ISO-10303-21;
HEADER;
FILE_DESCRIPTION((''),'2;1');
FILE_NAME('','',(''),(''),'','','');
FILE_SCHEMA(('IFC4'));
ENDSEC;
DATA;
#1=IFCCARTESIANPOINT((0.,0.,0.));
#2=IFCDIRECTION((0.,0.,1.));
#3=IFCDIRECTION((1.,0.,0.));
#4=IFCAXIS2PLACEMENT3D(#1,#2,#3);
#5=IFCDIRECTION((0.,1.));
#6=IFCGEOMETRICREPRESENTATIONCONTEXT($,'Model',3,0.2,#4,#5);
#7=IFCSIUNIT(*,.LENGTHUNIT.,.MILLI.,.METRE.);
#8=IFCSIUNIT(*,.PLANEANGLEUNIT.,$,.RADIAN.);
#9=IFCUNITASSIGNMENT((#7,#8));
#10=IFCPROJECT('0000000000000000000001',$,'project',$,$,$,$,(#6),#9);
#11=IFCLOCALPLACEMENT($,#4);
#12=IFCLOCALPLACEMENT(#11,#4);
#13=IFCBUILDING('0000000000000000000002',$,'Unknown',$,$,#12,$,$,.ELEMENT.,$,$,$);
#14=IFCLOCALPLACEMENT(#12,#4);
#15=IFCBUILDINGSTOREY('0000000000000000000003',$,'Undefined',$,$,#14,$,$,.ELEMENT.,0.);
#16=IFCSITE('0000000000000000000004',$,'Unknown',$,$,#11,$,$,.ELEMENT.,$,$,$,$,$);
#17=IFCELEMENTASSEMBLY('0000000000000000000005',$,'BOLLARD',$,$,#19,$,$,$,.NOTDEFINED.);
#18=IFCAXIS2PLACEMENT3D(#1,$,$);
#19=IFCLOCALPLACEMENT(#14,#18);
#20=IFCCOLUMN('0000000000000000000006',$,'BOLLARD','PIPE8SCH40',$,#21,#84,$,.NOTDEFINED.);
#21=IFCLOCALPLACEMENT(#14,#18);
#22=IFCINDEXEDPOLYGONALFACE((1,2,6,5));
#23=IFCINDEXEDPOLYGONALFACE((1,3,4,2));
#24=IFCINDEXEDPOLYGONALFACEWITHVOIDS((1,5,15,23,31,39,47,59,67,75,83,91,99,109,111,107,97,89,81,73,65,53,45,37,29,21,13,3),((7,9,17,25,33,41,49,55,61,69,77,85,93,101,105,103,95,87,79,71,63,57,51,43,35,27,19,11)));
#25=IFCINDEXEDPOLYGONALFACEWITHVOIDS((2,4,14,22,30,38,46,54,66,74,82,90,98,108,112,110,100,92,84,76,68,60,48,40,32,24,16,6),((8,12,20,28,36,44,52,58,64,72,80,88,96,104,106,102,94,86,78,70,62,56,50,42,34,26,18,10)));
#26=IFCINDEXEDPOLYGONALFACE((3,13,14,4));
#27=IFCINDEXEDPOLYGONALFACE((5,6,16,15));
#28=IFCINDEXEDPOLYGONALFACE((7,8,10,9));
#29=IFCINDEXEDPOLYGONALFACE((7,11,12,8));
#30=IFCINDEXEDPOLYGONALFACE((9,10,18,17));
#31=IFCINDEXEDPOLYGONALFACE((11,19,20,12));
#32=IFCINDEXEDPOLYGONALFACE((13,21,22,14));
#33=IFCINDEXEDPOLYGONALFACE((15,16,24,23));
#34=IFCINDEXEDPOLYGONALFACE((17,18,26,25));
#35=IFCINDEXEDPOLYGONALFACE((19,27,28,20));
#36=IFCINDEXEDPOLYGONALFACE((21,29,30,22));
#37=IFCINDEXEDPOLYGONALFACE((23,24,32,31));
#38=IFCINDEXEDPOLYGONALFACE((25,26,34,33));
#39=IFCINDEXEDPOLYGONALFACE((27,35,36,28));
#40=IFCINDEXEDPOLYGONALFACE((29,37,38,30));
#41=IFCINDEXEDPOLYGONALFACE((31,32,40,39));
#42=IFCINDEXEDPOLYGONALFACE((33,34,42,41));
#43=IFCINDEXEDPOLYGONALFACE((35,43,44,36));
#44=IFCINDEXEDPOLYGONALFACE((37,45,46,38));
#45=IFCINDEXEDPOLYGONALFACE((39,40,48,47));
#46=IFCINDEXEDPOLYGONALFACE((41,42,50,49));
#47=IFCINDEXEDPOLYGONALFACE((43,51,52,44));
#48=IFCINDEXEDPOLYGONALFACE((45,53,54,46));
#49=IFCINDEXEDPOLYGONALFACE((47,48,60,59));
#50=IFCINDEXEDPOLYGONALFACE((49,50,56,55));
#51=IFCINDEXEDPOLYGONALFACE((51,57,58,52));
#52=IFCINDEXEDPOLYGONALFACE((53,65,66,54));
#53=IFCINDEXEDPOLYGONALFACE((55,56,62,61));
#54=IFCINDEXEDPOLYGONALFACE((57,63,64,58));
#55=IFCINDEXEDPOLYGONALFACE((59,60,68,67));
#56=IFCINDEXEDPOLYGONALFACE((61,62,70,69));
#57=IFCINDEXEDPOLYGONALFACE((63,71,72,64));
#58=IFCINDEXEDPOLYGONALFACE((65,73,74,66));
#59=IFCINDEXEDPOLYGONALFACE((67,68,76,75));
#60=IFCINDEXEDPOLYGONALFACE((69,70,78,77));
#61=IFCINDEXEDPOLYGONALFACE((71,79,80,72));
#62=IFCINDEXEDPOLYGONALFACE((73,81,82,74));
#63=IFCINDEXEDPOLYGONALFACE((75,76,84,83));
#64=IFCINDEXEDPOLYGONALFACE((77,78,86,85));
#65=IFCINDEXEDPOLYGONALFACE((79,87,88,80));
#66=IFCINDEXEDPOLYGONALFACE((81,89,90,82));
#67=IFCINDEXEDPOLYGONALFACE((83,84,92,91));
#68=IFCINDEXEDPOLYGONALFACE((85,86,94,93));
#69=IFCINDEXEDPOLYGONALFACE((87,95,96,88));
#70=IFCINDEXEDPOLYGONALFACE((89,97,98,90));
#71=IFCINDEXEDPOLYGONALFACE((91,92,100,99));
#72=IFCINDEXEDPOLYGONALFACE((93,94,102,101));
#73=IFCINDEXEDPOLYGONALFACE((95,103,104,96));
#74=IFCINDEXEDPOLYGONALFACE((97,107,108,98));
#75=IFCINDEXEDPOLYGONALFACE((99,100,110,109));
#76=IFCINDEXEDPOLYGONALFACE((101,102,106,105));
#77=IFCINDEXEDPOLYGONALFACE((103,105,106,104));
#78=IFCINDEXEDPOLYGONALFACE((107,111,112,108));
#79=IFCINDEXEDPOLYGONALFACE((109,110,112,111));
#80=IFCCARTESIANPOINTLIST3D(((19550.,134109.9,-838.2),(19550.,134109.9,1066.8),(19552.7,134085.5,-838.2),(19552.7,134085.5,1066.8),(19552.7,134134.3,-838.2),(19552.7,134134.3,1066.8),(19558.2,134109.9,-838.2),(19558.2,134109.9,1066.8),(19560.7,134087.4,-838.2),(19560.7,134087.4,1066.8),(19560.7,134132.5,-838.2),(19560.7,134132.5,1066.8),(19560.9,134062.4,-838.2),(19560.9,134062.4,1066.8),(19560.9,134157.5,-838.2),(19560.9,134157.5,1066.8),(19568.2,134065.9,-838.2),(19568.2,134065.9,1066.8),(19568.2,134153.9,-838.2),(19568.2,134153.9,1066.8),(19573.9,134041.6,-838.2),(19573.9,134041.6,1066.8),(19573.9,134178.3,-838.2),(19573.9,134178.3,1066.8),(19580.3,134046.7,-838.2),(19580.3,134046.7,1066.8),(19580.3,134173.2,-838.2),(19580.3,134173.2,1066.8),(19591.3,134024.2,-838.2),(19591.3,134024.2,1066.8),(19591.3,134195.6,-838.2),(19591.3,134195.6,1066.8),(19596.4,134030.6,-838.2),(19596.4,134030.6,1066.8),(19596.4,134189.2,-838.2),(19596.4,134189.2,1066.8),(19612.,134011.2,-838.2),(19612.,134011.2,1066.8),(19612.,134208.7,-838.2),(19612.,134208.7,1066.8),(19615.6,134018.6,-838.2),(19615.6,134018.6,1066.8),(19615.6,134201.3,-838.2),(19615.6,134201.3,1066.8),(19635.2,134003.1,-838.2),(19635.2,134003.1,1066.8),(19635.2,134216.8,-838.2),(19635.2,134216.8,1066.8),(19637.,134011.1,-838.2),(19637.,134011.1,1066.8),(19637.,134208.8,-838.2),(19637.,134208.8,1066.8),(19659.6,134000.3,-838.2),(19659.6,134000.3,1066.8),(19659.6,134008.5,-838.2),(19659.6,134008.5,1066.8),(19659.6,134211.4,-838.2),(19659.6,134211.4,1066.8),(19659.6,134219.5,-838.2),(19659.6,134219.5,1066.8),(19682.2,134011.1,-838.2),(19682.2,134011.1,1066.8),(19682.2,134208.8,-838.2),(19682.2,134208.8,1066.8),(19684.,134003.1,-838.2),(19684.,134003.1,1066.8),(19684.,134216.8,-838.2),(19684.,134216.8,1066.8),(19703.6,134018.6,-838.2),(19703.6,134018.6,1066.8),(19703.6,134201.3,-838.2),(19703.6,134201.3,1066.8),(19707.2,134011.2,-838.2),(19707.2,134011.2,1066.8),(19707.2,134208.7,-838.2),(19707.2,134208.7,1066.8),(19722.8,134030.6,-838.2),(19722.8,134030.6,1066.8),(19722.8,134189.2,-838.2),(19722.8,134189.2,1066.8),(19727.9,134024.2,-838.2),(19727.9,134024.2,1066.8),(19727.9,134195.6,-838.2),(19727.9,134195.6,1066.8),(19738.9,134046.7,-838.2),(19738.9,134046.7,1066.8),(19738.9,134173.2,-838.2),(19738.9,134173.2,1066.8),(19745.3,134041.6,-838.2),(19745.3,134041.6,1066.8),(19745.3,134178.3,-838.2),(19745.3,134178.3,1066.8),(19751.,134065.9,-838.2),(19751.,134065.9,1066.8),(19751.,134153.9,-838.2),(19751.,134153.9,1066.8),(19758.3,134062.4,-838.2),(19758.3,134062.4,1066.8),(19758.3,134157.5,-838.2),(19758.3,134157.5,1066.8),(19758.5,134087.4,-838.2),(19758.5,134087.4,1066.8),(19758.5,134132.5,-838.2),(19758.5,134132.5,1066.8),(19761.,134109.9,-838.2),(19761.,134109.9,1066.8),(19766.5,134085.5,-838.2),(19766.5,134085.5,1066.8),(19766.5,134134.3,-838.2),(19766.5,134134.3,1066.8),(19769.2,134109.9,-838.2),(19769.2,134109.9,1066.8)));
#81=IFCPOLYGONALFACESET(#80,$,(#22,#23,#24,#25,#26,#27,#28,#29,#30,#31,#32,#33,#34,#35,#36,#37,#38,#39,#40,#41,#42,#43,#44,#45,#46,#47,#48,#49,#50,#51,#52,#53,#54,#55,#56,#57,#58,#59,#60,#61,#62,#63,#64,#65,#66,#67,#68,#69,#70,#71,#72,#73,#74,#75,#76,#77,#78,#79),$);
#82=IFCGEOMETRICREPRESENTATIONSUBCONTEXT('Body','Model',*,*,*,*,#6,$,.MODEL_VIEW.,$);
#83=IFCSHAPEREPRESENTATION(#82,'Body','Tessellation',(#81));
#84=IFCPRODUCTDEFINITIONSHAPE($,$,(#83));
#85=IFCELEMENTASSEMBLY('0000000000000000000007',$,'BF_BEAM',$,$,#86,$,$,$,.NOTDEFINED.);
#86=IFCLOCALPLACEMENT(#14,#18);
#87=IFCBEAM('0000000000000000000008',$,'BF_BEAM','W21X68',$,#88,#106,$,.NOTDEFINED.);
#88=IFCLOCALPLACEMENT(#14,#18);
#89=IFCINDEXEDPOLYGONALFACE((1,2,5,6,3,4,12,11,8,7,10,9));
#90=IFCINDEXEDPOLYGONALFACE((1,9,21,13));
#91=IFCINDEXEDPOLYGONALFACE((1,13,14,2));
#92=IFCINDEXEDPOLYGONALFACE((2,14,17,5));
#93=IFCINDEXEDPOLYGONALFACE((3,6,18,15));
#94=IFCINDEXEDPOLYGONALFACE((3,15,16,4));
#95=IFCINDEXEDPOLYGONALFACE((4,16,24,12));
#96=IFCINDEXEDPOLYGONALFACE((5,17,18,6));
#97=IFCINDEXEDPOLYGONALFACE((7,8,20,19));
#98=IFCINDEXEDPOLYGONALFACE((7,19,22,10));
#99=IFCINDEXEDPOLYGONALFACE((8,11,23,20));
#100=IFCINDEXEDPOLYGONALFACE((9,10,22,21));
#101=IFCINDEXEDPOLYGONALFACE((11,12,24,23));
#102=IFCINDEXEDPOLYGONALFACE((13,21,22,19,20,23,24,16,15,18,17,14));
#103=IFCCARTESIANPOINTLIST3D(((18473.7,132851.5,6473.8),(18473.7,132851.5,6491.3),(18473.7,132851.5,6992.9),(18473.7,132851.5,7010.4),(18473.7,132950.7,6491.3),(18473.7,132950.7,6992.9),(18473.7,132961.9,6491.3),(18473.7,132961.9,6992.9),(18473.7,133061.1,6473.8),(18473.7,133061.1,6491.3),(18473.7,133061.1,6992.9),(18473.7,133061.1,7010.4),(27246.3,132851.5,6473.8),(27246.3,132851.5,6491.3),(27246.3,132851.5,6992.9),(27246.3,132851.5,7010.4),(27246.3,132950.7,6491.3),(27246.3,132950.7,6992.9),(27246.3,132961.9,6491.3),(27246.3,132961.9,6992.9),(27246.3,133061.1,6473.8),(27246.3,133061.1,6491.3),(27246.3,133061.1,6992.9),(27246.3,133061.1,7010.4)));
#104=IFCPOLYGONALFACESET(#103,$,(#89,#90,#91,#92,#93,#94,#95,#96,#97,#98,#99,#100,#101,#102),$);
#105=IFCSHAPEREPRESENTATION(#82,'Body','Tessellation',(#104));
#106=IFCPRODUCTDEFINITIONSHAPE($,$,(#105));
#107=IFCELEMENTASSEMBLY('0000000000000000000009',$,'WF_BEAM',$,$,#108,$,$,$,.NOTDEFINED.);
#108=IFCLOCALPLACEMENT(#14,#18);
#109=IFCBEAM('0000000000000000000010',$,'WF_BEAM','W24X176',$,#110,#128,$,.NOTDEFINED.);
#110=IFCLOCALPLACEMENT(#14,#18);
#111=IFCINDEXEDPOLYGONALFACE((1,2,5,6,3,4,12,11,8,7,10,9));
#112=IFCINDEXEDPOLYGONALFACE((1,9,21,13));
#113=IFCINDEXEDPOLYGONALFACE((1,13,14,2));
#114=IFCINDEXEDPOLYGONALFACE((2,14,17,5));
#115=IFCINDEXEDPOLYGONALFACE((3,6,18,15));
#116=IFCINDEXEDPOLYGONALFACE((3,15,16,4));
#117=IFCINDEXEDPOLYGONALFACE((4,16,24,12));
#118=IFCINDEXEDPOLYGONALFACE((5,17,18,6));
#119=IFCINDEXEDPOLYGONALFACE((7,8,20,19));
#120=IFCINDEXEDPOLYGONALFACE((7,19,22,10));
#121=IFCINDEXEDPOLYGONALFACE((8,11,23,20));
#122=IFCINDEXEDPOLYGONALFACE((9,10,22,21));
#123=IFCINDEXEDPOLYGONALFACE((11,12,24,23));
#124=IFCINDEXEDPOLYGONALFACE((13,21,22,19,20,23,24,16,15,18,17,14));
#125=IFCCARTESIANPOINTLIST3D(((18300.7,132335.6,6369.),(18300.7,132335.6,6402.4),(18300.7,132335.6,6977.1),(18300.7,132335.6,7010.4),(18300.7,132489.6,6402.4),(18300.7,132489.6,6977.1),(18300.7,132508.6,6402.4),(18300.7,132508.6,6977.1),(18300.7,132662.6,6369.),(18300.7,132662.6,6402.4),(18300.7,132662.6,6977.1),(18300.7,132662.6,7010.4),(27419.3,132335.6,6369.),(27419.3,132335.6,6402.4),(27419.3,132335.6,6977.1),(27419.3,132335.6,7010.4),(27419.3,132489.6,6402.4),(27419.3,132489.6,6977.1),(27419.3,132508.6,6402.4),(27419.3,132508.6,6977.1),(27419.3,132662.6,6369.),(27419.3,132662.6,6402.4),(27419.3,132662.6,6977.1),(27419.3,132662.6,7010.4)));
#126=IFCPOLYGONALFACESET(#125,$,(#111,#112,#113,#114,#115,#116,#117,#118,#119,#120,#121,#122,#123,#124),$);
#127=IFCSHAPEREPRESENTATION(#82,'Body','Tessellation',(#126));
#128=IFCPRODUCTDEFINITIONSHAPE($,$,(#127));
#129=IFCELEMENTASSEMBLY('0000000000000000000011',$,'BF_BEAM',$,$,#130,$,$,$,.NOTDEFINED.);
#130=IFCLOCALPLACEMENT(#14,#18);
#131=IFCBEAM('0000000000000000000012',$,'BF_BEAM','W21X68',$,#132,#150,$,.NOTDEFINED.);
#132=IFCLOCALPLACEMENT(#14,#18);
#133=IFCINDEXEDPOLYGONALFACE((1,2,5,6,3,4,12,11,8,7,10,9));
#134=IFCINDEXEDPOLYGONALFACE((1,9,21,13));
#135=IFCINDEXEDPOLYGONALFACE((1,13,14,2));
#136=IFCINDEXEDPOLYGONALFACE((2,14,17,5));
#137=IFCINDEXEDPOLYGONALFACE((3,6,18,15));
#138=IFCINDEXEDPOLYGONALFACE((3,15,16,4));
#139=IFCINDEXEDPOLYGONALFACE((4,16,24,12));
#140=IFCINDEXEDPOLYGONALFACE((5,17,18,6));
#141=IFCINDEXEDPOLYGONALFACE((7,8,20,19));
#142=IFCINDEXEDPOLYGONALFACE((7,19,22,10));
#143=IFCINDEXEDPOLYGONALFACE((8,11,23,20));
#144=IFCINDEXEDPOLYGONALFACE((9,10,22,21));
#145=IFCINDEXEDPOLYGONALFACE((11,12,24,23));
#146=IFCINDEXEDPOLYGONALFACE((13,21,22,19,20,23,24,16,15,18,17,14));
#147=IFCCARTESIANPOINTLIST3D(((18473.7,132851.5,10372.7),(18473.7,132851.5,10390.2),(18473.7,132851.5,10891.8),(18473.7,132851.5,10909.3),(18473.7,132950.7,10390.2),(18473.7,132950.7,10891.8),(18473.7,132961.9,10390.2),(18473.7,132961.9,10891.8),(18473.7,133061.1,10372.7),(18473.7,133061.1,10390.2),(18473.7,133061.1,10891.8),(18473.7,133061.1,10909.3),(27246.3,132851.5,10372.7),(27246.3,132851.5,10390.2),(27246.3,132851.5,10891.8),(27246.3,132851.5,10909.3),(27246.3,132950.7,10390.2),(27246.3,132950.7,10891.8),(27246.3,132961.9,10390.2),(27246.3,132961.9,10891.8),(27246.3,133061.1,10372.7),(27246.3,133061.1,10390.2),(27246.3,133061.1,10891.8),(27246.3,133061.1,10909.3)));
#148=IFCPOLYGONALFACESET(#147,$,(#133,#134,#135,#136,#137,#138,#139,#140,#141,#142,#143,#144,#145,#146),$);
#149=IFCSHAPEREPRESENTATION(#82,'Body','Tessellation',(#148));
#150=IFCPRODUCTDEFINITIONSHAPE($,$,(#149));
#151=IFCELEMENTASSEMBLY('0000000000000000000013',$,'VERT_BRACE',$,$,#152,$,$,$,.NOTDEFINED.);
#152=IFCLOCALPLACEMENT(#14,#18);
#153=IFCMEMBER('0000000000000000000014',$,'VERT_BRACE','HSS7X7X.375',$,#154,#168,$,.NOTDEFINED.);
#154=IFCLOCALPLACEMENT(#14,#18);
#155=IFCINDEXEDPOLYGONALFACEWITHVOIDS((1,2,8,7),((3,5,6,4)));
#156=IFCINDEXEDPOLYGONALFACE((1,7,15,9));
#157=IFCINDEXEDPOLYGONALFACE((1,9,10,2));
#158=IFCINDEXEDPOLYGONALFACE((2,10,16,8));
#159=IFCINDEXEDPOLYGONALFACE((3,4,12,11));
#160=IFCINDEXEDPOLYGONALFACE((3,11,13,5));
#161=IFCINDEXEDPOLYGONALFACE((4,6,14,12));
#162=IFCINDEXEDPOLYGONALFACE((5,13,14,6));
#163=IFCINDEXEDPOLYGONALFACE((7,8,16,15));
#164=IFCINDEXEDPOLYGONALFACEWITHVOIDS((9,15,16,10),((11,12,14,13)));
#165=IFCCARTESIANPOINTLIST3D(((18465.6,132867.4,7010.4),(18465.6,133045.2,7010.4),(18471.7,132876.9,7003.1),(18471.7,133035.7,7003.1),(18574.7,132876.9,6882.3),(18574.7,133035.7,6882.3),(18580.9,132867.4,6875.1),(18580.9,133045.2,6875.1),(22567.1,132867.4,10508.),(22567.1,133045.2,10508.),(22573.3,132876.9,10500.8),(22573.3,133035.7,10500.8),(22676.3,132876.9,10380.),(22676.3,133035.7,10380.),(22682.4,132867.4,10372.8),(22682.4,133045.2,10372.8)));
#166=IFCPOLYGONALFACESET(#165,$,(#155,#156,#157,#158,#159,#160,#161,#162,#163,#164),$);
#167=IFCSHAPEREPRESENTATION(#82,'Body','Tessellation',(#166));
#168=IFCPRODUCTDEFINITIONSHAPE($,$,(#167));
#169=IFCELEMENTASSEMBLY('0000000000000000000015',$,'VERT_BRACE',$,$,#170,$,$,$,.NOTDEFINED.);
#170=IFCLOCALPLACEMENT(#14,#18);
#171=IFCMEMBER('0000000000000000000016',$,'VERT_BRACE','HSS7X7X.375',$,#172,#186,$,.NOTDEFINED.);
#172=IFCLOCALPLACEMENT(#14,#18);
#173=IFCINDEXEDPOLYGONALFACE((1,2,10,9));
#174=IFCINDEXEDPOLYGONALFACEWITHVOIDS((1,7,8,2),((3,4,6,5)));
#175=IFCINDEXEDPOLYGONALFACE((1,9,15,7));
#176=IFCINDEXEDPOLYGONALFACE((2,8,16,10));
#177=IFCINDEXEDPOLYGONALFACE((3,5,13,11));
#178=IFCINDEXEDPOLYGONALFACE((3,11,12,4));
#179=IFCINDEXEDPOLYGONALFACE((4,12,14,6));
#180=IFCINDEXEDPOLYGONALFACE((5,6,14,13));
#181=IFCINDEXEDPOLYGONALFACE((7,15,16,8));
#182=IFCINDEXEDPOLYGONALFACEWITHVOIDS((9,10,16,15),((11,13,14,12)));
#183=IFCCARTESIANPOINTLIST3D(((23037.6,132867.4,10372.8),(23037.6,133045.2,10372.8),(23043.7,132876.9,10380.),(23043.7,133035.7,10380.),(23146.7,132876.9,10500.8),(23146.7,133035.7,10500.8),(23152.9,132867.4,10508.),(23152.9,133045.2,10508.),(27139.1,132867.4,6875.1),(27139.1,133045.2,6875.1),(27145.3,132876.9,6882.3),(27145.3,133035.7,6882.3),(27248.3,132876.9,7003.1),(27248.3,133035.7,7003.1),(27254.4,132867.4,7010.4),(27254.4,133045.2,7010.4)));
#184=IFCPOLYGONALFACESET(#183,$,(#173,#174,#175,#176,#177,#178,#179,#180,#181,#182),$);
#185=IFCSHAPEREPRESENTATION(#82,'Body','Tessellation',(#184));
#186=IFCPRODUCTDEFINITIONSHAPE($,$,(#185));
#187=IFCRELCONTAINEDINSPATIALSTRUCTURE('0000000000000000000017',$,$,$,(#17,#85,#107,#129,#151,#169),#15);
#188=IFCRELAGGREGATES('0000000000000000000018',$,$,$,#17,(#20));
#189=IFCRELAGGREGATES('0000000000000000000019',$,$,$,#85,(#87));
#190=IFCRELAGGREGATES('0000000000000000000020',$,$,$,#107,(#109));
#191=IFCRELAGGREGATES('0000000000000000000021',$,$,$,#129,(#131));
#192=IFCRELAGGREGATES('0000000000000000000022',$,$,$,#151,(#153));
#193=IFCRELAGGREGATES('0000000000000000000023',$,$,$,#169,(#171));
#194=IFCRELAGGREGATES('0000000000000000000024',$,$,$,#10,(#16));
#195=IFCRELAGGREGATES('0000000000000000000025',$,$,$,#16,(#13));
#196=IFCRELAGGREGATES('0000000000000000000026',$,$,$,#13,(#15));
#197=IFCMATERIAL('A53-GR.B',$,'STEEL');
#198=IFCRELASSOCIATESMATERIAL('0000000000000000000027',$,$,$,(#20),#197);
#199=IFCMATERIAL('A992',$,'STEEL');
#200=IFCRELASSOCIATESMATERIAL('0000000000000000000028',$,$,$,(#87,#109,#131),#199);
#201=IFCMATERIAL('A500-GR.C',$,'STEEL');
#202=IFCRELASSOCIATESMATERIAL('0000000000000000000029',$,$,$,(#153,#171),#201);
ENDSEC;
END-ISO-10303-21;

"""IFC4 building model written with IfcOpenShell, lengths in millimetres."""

from ifc_helpers import new_model, si_unit, direction, frame, origin_with_axes, place, context, subcontext, project, spatial, line, indexed_curve, outline, extrude, material, element, aggregate, save


model = new_model("IFC4")

# Units and contexts
model_context = context("Model", 3, precision=0.2, world=origin_with_axes(), true_north=direction((0.0, 1.0)))
body_context = subcontext(model_context, "Body", "Model", "MODEL_VIEW")
ifc_project = project(units=[si_unit("LENGTHUNIT", "METRE", prefix="MILLI"), si_unit("PLANEANGLEUNIT", "RADIAN")], contexts=[model_context])

# Site, building, storey
site_placement = place(None, origin_with_axes())
site = spatial("IfcSite", under=ifc_project, at=site_placement, Name="Unknown", CompositionType="ELEMENT")
building_placement = place(site_placement, origin_with_axes())
building = spatial("IfcBuilding", under=site, at=building_placement, Name="Unknown", CompositionType="ELEMENT")
storey_placement = place(building_placement, origin_with_axes())
storey = spatial("IfcBuildingStorey", under=building, at=storey_placement, Name="Undefined", CompositionType="ELEMENT", Elevation=0.0)

# Element assembly, column
ifc_material_1 = material(Name="A992", Category="STEEL")
ifc_material_2 = material(Name="A500-GR.C", Category="STEEL")
ifc_material_3 = material(Name="A53-GR.B", Category="STEEL")
assembly_1_placement = place(storey_placement, frame((19659.6, 134109.9, -838.2), z_axis=(-1.0, 0.0, 0.0), x_axis=(0.0, 0.0, 1.0)))
assembly_1 = element("IfcElementAssembly", 1, at=assembly_1_placement, inside=storey, Name="BOLLARD", PredefinedType="NOTDEFINED")
column_1_placement = place(assembly_1_placement, origin_with_axes())
column_1 = element("IfcColumn", 2, at=column_1_placement, material=ifc_material_3, Name="BOLLARD", Description="PIPE8SCH40", PredefinedType="NOTDEFINED", context=body_context, shape_type="SolidModel", body=[
    extrude(outline(indexed_curve([(109.6, 0.0), (106.9, 24.4), (98.7, 47.6), (85.7, 68.3), (68.3, 85.7), (47.6, 98.7), (24.4, 106.9), (0.0, 109.6), (-24.4, 106.9), (-47.6, 98.7), (-68.3, 85.7), (-85.7, 68.3), (-98.7, 47.6), (-106.9, 24.4), (-109.6, 0.0), (-106.9, -24.4), (-98.7, -47.6), (-85.7, -68.3), (-68.3, -85.7), (-47.6, -98.7), (-24.4, -106.9), (0.0, -109.6), (24.4, -106.9), (47.6, -98.7), (68.3, -85.7), (85.7, -68.3), (98.7, -47.6), (106.9, -24.4)], segments=[line(1, 2, 3, 4, 5, 6, 7, 8, 9, 10, 11, 12, 13, 14, 15, 16, 17, 18, 19, 20, 21, 22, 23, 24, 25, 26, 27, 28, 1)]), holes=[indexed_curve([(101.4, 0.0), (98.9, -22.6), (91.4, -44.0), (79.3, -63.2), (63.2, -79.3), (44.0, -91.4), (22.6, -98.9), (0.0, -101.4), (-22.6, -98.9), (-44.0, -91.4), (-63.2, -79.3), (-79.3, -63.2), (-91.4, -44.0), (-98.9, -22.6), (-101.4, 0.0), (-98.9, 22.6), (-91.4, 44.0), (-79.3, 63.2), (-63.2, 79.3), (-44.0, 91.4), (-22.6, 98.9), (0.0, 101.4), (22.6, 98.9), (44.0, 91.4), (63.2, 79.3), (79.3, 63.2), (91.4, 44.0), (98.9, 22.6)], segments=[line(1, 2, 3, 4, 5, 6, 7, 8, 9, 10, 11, 12, 13, 14, 15, 16, 17, 18, 19, 20, 21, 22, 23, 24, 25, 26, 27, 28, 1)])]), frame((0.0, 0.0, 0.0), z_axis=(-1.0, 0.0, 0.0), x_axis=(0.0, 0.0, 1.0)), (0.0, 0.0, -1.0), 1905.0),
])
aggregate(assembly_1, [column_1])

# Element assemblies, beams
assembly_2_placement = place(storey_placement, frame((18473.7, 132956.3, 6742.1), z_axis=(0.0, -1.0, 0.0), x_axis=(1.0, 0.0, 0.0)))
assembly_2 = element("IfcElementAssembly", 3, at=assembly_2_placement, inside=storey, Name="BF_BEAM", PredefinedType="NOTDEFINED")
beam_1_placement = place(assembly_2_placement, origin_with_axes())
beam_1 = element("IfcBeam", 4, at=beam_1_placement, material=ifc_material_1, Name="BF_BEAM", Description="W21X68", PredefinedType="NOTDEFINED", context=body_context, shape_type="SolidModel", body=[
    extrude(outline(indexed_curve([(-104.8, -268.3), (104.8, -268.3), (104.8, -250.8), (5.6, -250.8), (5.6, 250.8), (104.8, 250.8), (104.8, 268.3), (-104.8, 268.3), (-104.8, 250.8), (-5.6, 250.8), (-5.6, -250.8), (-104.8, -250.8)], segments=[line(1, 2, 3, 4, 5, 6, 7, 8, 9, 10, 11, 12, 1)])), frame((0.0, 0.0, 0.0), z_axis=(-1.0, 0.0, 0.0), x_axis=(0.0, 0.0, 1.0)), (0.0, 0.0, -1.0), 8772.5),
])
aggregate(assembly_2, [beam_1])
assembly_3_placement = place(storey_placement, frame((18300.7, 132499.1, 6689.7), z_axis=(0.0, -1.0, 0.0), x_axis=(1.0, 0.0, 0.0)))
assembly_3 = element("IfcElementAssembly", 5, at=assembly_3_placement, inside=storey, Name="WF_BEAM", PredefinedType="NOTDEFINED")
beam_2_placement = place(assembly_3_placement, origin_with_axes())
beam_2 = element("IfcBeam", 6, at=beam_2_placement, material=ifc_material_1, Name="WF_BEAM", Description="W24X176", PredefinedType="NOTDEFINED", context=body_context, shape_type="SolidModel", body=[
    extrude(outline(indexed_curve([(-163.5, -320.7), (163.5, -320.7), (163.5, -287.3), (9.5, -287.3), (9.5, 287.3), (163.5, 287.3), (163.5, 320.7), (-163.5, 320.7), (-163.5, 287.3), (-9.5, 287.3), (-9.5, -287.3), (-163.5, -287.3)], segments=[line(1, 2, 3, 4, 5, 6, 7, 8, 9, 10, 11, 12, 1)])), frame((0.0, 0.0, 0.0), z_axis=(-1.0, 0.0, 0.0), x_axis=(0.0, 0.0, 1.0)), (0.0, 0.0, -1.0), 9118.6),
])
aggregate(assembly_3, [beam_2])
assembly_4_placement = place(storey_placement, frame((18473.7, 132956.3, 10641.0), z_axis=(0.0, -1.0, 0.0), x_axis=(1.0, 0.0, 0.0)))
assembly_4 = element("IfcElementAssembly", 7, at=assembly_4_placement, inside=storey, Name="BF_BEAM", PredefinedType="NOTDEFINED")
beam_3_placement = place(assembly_4_placement, origin_with_axes())
beam_3 = element("IfcBeam", 8, at=beam_3_placement, material=ifc_material_1, Name="BF_BEAM", Description="W21X68", PredefinedType="NOTDEFINED", context=body_context, shape_type="SolidModel", body=[
    extrude(outline(indexed_curve([(-104.8, -268.3), (104.8, -268.3), (104.8, -250.8), (5.6, -250.8), (5.6, 250.8), (104.8, 250.8), (104.8, 268.3), (-104.8, 268.3), (-104.8, 250.8), (-5.6, 250.8), (-5.6, -250.8), (-104.8, -250.8)], segments=[line(1, 2, 3, 4, 5, 6, 7, 8, 9, 10, 11, 12, 1)])), frame((0.0, 0.0, 0.0), z_axis=(-1.0, 0.0, 0.0), x_axis=(0.0, 0.0, 1.0)), (0.0, 0.0, -1.0), 8772.5),
])
aggregate(assembly_4, [beam_3])

# Element assemblies, members
assembly_5_placement = place(storey_placement, frame((18523.2, 132956.3, 6942.7), z_axis=(0.0, -1.0, 0.0), x_axis=(0.760895, 0.0, 0.648875)))
assembly_5 = element("IfcElementAssembly", 9, at=assembly_5_placement, inside=storey, Name="VERT_BRACE", PredefinedType="NOTDEFINED")
member_1_placement = place(assembly_5_placement, origin_with_axes())
member_1 = element("IfcMember", 10, at=member_1_placement, material=ifc_material_2, Name="VERT_BRACE", Description="HSS7X7X.375", PredefinedType="NOTDEFINED", context=body_context, shape_type="SolidModel", body=[
    extrude(outline(indexed_curve([(-88.9, -88.9), (88.9, -88.9), (88.9, 88.9), (-88.9, 88.9)], segments=[line(1, 2, 3, 4, 1)]), holes=[indexed_curve([(-79.4, -79.4), (-79.4, 79.4), (79.4, 79.4), (79.4, -79.4)], segments=[line(1, 2, 3, 4, 1)])]), frame((0.0, 0.0, 0.0), z_axis=(-1.0, 0.0, 0.0), x_axis=(0.0, 0.0, 1.0)), (0.0, 0.0, -1.0), 5390.4),
])
aggregate(assembly_5, [member_1])
assembly_6_placement = place(storey_placement, frame((27196.8, 132956.3, 6942.7), z_axis=(0.0, 1.0, 0.0), x_axis=(-0.760895, 0.0, 0.648875)))
assembly_6 = element("IfcElementAssembly", 11, at=assembly_6_placement, inside=storey, Name="VERT_BRACE", PredefinedType="NOTDEFINED")
member_2_placement = place(assembly_6_placement, origin_with_axes())
member_2 = element("IfcMember", 12, at=member_2_placement, material=ifc_material_2, Name="VERT_BRACE", Description="HSS7X7X.375", PredefinedType="NOTDEFINED", context=body_context, shape_type="SolidModel", body=[
    extrude(outline(indexed_curve([(-88.9, -88.9), (88.9, -88.9), (88.9, 88.9), (-88.9, 88.9)], segments=[line(1, 2, 3, 4, 1)]), holes=[indexed_curve([(-79.4, -79.4), (-79.4, 79.4), (79.4, 79.4), (79.4, -79.4)], segments=[line(1, 2, 3, 4, 1)])]), frame((0.0, 0.0, 0.0), z_axis=(-1.0, 0.0, 0.0), x_axis=(0.0, 0.0, 1.0)), (0.0, 0.0, -1.0), 5390.4),
])
aggregate(assembly_6, [member_2])

save(model, "model.ifc")
